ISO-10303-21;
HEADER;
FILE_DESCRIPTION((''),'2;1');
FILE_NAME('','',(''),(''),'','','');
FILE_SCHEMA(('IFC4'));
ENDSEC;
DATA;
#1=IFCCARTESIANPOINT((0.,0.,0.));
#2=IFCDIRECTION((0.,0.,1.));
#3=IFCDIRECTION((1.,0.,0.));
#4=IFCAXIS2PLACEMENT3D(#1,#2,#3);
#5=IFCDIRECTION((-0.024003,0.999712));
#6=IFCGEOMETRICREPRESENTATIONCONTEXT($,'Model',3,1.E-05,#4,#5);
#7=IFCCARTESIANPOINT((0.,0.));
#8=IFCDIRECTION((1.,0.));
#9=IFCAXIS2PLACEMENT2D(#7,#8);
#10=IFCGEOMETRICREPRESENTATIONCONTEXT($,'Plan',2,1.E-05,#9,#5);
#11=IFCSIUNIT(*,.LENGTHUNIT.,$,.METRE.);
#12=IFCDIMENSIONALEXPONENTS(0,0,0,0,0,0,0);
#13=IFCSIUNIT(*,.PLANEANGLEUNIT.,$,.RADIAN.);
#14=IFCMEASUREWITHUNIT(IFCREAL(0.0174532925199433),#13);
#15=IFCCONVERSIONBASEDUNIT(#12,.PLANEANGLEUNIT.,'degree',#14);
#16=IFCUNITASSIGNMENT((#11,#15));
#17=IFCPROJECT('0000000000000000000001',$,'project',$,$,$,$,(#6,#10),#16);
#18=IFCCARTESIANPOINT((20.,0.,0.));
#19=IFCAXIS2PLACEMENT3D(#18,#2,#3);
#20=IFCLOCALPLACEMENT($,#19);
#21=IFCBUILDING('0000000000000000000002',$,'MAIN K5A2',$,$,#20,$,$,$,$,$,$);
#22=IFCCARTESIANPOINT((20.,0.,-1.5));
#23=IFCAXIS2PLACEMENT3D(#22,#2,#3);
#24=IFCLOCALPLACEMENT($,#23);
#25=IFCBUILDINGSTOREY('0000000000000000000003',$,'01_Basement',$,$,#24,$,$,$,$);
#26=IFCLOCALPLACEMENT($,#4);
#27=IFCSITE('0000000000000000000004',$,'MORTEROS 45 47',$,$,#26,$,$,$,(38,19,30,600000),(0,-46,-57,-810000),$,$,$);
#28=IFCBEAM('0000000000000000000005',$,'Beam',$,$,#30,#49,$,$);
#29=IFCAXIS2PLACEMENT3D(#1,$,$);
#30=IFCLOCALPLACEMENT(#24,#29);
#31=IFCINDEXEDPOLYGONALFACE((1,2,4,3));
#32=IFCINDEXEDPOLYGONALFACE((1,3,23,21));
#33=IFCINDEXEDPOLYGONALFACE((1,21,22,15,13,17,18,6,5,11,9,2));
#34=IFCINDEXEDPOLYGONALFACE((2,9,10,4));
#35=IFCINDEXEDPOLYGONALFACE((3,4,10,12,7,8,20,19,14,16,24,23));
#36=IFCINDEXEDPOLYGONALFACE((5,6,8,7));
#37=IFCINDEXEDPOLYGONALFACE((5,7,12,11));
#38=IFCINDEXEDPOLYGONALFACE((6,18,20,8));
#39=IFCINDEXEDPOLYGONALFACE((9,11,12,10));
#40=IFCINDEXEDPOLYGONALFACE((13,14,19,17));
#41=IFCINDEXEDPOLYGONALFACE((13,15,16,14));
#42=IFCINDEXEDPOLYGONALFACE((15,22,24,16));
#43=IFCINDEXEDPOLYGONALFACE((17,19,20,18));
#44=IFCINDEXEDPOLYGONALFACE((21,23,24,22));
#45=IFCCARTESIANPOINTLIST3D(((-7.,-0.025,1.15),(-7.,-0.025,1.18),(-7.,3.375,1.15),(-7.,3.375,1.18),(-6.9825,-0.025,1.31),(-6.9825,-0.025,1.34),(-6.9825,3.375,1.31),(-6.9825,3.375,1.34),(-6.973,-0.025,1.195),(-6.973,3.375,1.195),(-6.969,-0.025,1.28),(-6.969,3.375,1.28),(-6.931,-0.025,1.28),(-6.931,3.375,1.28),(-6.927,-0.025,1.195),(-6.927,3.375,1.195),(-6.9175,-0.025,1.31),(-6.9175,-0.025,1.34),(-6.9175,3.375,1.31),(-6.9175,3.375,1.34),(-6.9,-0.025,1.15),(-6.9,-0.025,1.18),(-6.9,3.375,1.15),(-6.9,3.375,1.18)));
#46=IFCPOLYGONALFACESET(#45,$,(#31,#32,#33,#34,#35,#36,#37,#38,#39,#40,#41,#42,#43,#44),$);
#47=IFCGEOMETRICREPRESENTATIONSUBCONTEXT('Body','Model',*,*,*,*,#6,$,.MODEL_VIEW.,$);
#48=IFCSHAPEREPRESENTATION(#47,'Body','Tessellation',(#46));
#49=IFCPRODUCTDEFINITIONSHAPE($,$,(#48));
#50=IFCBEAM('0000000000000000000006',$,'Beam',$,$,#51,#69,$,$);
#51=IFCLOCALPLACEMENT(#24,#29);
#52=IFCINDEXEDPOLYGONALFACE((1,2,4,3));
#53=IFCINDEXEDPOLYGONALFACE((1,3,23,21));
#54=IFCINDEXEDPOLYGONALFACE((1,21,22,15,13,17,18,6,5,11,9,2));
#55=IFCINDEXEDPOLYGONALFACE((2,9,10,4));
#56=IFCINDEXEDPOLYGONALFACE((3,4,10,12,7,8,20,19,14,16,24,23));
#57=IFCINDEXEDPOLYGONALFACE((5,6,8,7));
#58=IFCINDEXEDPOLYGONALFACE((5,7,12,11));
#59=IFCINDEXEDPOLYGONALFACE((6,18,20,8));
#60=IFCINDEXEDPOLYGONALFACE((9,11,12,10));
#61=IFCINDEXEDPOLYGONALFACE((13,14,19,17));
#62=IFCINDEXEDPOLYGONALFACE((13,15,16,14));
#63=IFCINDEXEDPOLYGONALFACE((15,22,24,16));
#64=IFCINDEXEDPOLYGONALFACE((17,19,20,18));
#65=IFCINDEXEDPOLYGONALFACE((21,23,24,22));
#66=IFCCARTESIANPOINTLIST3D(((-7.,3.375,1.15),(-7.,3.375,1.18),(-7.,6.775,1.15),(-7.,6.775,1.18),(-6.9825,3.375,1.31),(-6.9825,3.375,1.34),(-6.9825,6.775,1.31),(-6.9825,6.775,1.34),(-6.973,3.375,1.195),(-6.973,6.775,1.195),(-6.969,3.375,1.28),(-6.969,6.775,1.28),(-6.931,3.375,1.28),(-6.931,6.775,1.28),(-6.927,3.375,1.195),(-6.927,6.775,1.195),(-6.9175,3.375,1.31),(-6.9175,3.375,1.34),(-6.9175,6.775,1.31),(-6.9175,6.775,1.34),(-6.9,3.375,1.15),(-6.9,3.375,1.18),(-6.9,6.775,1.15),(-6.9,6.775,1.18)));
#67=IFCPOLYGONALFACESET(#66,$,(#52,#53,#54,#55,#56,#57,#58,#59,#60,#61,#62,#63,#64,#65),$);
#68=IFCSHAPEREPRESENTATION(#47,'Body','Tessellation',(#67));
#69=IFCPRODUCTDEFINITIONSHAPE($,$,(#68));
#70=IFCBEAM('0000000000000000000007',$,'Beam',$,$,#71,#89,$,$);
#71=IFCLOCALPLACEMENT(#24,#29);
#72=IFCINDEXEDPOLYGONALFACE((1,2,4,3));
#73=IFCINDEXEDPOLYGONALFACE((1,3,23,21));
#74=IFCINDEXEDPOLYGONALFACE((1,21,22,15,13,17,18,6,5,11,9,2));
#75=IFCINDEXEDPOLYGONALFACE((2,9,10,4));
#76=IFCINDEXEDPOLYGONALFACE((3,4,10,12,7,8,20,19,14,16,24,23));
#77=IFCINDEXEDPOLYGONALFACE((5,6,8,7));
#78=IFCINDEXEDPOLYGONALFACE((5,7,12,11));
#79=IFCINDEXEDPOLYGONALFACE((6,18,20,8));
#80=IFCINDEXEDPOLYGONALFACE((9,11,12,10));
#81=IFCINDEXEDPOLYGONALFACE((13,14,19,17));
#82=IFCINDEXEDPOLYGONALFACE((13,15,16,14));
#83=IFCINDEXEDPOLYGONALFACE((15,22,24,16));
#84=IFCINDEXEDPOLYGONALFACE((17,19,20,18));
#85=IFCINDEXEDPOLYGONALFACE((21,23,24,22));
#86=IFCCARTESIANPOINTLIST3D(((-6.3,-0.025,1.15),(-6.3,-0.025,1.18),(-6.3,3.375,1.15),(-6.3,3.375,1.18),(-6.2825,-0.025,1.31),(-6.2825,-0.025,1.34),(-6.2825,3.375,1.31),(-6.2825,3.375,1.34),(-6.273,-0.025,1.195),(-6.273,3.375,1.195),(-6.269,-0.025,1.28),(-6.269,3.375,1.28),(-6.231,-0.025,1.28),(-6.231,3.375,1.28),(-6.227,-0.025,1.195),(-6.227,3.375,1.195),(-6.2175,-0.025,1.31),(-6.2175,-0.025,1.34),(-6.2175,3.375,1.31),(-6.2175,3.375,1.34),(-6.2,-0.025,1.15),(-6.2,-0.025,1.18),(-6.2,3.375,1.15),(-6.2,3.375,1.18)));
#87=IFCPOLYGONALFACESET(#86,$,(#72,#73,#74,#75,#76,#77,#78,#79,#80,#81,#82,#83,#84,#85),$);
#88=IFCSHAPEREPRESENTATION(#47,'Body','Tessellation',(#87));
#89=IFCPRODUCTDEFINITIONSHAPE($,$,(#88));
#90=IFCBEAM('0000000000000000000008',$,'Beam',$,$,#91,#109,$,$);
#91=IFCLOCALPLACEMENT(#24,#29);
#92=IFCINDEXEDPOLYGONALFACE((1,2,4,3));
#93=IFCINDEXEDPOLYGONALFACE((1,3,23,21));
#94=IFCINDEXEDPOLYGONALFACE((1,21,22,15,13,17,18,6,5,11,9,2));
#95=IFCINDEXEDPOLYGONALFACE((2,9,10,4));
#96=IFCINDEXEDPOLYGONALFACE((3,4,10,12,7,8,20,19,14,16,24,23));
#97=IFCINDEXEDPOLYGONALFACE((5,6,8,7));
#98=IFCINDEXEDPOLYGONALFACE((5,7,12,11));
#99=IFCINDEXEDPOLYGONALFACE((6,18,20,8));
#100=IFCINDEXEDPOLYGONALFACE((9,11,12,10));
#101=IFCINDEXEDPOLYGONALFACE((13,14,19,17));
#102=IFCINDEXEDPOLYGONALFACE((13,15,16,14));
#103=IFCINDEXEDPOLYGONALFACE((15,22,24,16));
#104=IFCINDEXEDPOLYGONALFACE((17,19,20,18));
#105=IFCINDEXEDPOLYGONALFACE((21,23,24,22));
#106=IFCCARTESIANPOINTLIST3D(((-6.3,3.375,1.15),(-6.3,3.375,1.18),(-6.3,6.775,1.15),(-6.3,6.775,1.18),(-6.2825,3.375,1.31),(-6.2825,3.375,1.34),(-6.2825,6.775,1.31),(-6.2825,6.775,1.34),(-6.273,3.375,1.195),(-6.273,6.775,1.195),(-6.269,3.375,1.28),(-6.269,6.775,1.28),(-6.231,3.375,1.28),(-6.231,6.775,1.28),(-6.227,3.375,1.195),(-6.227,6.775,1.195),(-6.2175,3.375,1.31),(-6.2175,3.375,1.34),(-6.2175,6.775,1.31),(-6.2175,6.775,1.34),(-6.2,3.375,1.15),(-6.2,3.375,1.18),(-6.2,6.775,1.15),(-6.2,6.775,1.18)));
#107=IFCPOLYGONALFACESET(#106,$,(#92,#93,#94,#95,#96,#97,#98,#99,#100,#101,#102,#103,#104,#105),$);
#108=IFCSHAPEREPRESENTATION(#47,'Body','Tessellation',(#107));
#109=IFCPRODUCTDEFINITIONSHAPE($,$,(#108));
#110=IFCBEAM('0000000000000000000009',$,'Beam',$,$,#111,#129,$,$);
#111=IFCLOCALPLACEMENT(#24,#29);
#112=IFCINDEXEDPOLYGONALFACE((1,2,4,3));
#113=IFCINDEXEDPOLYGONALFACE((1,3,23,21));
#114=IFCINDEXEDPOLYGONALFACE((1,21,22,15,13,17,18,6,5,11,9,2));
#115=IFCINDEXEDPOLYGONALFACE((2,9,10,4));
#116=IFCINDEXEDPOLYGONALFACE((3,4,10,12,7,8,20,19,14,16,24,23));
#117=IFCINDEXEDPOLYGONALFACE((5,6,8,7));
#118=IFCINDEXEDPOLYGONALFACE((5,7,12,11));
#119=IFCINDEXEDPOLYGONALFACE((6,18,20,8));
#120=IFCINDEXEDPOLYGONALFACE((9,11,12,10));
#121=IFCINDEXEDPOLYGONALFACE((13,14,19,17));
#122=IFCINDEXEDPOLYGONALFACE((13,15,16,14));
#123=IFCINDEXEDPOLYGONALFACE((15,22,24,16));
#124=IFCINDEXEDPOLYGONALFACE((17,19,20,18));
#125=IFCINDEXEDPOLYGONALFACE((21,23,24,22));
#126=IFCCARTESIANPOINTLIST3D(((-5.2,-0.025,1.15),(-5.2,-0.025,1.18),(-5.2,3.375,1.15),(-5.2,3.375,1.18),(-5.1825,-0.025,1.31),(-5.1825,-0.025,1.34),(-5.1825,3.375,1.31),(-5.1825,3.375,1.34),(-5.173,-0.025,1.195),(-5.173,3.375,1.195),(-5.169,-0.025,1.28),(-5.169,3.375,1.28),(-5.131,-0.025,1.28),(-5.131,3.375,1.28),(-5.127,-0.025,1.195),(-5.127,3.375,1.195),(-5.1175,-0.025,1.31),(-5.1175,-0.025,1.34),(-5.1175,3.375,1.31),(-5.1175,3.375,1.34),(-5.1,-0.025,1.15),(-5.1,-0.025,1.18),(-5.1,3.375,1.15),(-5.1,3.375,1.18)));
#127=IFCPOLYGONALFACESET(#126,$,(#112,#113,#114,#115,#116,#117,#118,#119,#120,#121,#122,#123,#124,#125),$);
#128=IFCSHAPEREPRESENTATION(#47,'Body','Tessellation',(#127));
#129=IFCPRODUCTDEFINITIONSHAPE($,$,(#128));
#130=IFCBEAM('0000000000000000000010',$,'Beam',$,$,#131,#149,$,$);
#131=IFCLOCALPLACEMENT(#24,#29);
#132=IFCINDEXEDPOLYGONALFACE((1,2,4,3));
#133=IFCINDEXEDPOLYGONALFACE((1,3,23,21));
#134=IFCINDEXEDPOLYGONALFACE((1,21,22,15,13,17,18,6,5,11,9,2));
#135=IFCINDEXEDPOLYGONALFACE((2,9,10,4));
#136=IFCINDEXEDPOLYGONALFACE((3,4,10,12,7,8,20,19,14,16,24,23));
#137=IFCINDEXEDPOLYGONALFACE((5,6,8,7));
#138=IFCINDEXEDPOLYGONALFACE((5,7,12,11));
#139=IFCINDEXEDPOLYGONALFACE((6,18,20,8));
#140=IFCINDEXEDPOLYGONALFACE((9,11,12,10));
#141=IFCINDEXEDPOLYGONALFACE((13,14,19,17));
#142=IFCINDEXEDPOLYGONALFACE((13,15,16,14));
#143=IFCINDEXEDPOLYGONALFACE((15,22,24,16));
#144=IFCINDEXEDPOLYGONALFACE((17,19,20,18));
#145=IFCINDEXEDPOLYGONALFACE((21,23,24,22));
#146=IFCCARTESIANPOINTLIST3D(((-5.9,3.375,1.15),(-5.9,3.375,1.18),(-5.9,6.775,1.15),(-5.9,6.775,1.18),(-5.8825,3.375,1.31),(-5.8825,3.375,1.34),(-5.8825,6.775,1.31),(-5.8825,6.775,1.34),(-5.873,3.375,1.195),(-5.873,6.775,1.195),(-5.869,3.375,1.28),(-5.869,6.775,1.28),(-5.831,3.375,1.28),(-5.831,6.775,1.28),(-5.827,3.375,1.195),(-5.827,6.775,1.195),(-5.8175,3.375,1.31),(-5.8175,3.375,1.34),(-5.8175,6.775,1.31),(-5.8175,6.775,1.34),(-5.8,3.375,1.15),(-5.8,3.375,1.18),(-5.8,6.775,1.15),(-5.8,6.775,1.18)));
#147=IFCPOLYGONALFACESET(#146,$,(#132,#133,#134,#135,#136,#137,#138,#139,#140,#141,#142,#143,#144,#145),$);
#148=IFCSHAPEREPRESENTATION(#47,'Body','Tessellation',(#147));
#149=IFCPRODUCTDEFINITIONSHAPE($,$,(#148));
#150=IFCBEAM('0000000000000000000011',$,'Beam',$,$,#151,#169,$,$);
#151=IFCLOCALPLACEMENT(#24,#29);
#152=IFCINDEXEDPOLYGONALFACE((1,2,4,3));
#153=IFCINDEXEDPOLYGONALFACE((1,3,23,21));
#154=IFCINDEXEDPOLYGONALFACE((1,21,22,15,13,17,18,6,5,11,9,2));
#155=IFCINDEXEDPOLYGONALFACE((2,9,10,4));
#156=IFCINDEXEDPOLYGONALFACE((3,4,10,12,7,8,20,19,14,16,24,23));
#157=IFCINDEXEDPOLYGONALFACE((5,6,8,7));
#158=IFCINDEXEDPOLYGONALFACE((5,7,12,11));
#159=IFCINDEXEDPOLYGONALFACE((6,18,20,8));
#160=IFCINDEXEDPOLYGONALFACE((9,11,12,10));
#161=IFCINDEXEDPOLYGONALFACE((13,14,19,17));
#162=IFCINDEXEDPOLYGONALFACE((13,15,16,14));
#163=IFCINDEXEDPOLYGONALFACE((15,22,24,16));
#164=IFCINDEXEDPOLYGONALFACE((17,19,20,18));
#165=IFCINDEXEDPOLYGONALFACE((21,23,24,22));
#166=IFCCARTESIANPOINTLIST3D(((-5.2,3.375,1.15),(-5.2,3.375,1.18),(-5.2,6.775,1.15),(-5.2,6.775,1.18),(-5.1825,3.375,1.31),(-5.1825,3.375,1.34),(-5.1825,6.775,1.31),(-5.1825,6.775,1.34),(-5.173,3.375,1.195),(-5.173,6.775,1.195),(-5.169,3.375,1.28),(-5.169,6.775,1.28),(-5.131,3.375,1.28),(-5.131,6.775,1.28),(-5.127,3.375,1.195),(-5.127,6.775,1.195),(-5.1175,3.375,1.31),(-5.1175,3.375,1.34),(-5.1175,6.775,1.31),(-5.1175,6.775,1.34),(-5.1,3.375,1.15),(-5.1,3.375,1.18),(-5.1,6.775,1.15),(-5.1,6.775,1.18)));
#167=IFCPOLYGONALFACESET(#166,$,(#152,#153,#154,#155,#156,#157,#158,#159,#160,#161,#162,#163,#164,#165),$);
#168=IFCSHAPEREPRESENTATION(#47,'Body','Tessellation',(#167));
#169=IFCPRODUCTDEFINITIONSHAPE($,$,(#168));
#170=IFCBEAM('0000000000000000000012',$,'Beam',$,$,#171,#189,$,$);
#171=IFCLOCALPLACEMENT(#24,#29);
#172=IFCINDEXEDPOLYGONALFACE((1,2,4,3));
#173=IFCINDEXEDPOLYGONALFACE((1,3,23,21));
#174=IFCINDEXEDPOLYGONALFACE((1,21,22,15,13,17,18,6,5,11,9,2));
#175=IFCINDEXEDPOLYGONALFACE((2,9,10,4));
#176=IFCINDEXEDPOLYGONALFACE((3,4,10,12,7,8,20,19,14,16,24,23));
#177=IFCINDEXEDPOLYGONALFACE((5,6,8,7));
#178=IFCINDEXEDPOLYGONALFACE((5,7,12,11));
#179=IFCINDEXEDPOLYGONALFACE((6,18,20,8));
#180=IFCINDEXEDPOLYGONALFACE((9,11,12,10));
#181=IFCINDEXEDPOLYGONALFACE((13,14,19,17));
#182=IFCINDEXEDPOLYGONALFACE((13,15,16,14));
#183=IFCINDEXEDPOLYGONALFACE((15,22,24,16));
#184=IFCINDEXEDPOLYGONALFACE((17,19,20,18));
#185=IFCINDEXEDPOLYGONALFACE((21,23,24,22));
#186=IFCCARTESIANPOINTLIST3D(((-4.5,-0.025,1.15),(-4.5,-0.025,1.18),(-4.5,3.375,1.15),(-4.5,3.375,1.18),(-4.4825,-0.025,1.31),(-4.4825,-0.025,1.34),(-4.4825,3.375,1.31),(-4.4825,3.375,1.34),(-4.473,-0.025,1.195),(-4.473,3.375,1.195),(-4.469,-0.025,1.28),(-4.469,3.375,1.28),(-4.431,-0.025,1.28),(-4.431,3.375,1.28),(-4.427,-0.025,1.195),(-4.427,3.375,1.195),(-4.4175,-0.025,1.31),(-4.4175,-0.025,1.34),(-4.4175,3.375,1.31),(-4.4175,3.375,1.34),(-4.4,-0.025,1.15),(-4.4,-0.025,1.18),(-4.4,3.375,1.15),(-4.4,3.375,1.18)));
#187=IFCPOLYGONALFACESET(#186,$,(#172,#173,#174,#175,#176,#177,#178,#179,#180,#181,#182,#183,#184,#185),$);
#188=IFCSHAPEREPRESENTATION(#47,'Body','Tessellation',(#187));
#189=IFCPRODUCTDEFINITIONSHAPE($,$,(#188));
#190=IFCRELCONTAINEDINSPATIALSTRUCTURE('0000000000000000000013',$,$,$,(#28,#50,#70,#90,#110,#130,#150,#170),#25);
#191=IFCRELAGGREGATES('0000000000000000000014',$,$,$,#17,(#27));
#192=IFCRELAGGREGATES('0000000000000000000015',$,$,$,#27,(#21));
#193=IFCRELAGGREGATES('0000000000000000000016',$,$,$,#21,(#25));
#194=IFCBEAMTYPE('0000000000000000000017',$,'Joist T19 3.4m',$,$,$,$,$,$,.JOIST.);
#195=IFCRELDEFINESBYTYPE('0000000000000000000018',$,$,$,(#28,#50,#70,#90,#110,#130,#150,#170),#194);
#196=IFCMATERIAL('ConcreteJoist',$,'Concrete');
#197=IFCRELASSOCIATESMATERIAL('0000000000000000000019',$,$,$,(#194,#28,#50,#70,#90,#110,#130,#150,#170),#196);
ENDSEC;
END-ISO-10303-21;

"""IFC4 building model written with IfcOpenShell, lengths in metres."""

from ifc_helpers import new_model, entity, si_unit, converted_unit, direction, frame, origin_with_axes, origin_2d_with_axis, place, context, subcontext, project, spatial, indexed_curve, outline, extrude, material, material_profile, profile_set, profile_usage, type_object, element, save


model = new_model("IFC4")

# Units and contexts
model_context = context("Model", 3, precision=1e-05, world=origin_with_axes(), true_north=direction((-0.024003, 0.999712)))
plan_context = context("Plan", 2, precision=1e-05, world=origin_2d_with_axis(), true_north=direction((-0.024003, 0.999712)))
body_context = subcontext(model_context, "Body", "Model", "MODEL_VIEW")
ifc_project = project(units=[si_unit("LENGTHUNIT", "METRE"), converted_unit("PLANEANGLEUNIT", "degree", entity("IfcReal", 0.0174532925199433), si_unit("PLANEANGLEUNIT", "RADIAN"), dimensions=[0, 0, 0, 0, 0, 0, 0])], contexts=[model_context, plan_context])

# Site, building, storey
site_placement = place(None, origin_with_axes())
site = spatial("IfcSite", under=ifc_project, at=site_placement, Name="MORTEROS 45 47", RefLatitude=(38, 19, 30, 600000), RefLongitude=(0, -46, -57, -810000))
building_placement = place(None, frame((20.0, 0.0, 0.0), z_axis=(0.0, 0.0, 1.0), x_axis=(1.0, 0.0, 0.0)))
building = spatial("IfcBuilding", under=site, at=building_placement, Name="MAIN K5A2")
storey_placement = place(None, frame((20.0, 0.0, -1.5), z_axis=(0.0, 0.0, 1.0), x_axis=(1.0, 0.0, 0.0)))
storey = spatial("IfcBuildingStorey", under=building, at=storey_placement, Name="01_Basement")

# Beams
ifc_material = material(Name="ConcreteJoist", Category="Concrete")
ifc_material_profile = material_profile(ifc_material, outline(indexed_curve([(0.019, 0.13), (0.023, 0.045), (0.05, 0.03), (0.05, 0.0), (-0.05, 0.0), (-0.05, 0.03), (-0.023, 0.045), (-0.019, 0.13), (-0.0325, 0.16), (-0.0325, 0.19), (0.0325, 0.19), (0.0325, 0.16), (0.019, 0.13)])))
ifc_profile_set = profile_set([ifc_material_profile], Name="JoistMaterialProfileSet")
ifc_profile_usage_1 = profile_usage(ifc_profile_set, cardinal=5)
beam_type = type_object("IfcBeamType", Name="Joist T19 3.4m", PredefinedType="JOIST", material=ifc_profile_set)
beam_1_placement = place(None, frame((13.05, -0.025, -0.35), z_axis=(0.0, 1.0, 0.0), x_axis=(-1.0, 0.0, 0.0)))
element("IfcBeam", 1, at=beam_1_placement, inside=storey, type_object=beam_type, material=ifc_profile_usage_1, Name="Beam", context=body_context, shape_type="SweptSolid", body=[
    extrude(outline(indexed_curve([(0.019, 0.13), (0.023, 0.045), (0.05, 0.03), (0.05, 0.0), (-0.05, 0.0), (-0.05, 0.03), (-0.023, 0.045), (-0.019, 0.13), (-0.0325, 0.16), (-0.0325, 0.19), (0.0325, 0.19), (0.0325, 0.16), (0.019, 0.13)])), origin_with_axes(), (0.0, 0.0, 1.0), 3.4),
])
ifc_profile_usage_2 = profile_usage(ifc_profile_set, cardinal=5)
beam_2_placement = place(None, frame((13.05, 3.375, -0.35), z_axis=(0.0, 1.0, 0.0), x_axis=(-1.0, 0.0, 0.0)))
element("IfcBeam", 2, at=beam_2_placement, inside=storey, type_object=beam_type, material=ifc_profile_usage_2, Name="Beam", context=body_context, shape_type="SweptSolid", body=[
    extrude(outline(indexed_curve([(0.019, 0.13), (0.023, 0.045), (0.05, 0.03), (0.05, 0.0), (-0.05, 0.0), (-0.05, 0.03), (-0.023, 0.045), (-0.019, 0.13), (-0.0325, 0.16), (-0.0325, 0.19), (0.0325, 0.19), (0.0325, 0.16), (0.019, 0.13)])), origin_with_axes(), (0.0, 0.0, 1.0), 3.4),
])
ifc_profile_usage_3 = profile_usage(ifc_profile_set, cardinal=5)
beam_3_placement = place(None, frame((13.75, -0.025, -0.35), z_axis=(0.0, 1.0, 0.0), x_axis=(-1.0, 0.0, 0.0)))
element("IfcBeam", 3, at=beam_3_placement, inside=storey, type_object=beam_type, material=ifc_profile_usage_3, Name="Beam", context=body_context, shape_type="SweptSolid", body=[
    extrude(outline(indexed_curve([(0.019, 0.13), (0.023, 0.045), (0.05, 0.03), (0.05, 0.0), (-0.05, 0.0), (-0.05, 0.03), (-0.023, 0.045), (-0.019, 0.13), (-0.0325, 0.16), (-0.0325, 0.19), (0.0325, 0.19), (0.0325, 0.16), (0.019, 0.13)])), origin_with_axes(), (0.0, 0.0, 1.0), 3.4),
])
ifc_profile_usage_4 = profile_usage(ifc_profile_set, cardinal=5)
beam_4_placement = place(None, frame((13.75, 3.375, -0.35), z_axis=(0.0, 1.0, 0.0), x_axis=(-1.0, 0.0, 0.0)))
element("IfcBeam", 4, at=beam_4_placement, inside=storey, type_object=beam_type, material=ifc_profile_usage_4, Name="Beam", context=body_context, shape_type="SweptSolid", body=[
    extrude(outline(indexed_curve([(0.019, 0.13), (0.023, 0.045), (0.05, 0.03), (0.05, 0.0), (-0.05, 0.0), (-0.05, 0.03), (-0.023, 0.045), (-0.019, 0.13), (-0.0325, 0.16), (-0.0325, 0.19), (0.0325, 0.19), (0.0325, 0.16), (0.019, 0.13)])), origin_with_axes(), (0.0, 0.0, 1.0), 3.4),
])
ifc_profile_usage_5 = profile_usage(ifc_profile_set, cardinal=5)
beam_5_placement = place(None, frame((14.85, -0.025, -0.35), z_axis=(0.0, 1.0, 0.0), x_axis=(-1.0, 0.0, 0.0)))
element("IfcBeam", 5, at=beam_5_placement, inside=storey, type_object=beam_type, material=ifc_profile_usage_5, Name="Beam", context=body_context, shape_type="SweptSolid", body=[
    extrude(outline(indexed_curve([(0.019, 0.13), (0.023, 0.045), (0.05, 0.03), (0.05, 0.0), (-0.05, 0.0), (-0.05, 0.03), (-0.023, 0.045), (-0.019, 0.13), (-0.0325, 0.16), (-0.0325, 0.19), (0.0325, 0.19), (0.0325, 0.16), (0.019, 0.13)])), origin_with_axes(), (0.0, 0.0, 1.0), 3.4),
])
ifc_profile_usage_6 = profile_usage(ifc_profile_set, cardinal=5)
beam_6_placement = place(None, frame((14.15, 3.375, -0.35), z_axis=(0.0, 1.0, 0.0), x_axis=(-1.0, 0.0, 0.0)))
element("IfcBeam", 6, at=beam_6_placement, inside=storey, type_object=beam_type, material=ifc_profile_usage_6, Name="Beam", context=body_context, shape_type="SweptSolid", body=[
    extrude(outline(indexed_curve([(0.019, 0.13), (0.023, 0.045), (0.05, 0.03), (0.05, 0.0), (-0.05, 0.0), (-0.05, 0.03), (-0.023, 0.045), (-0.019, 0.13), (-0.0325, 0.16), (-0.0325, 0.19), (0.0325, 0.19), (0.0325, 0.16), (0.019, 0.13)])), origin_with_axes(), (0.0, 0.0, 1.0), 3.4),
])
ifc_profile_usage_7 = profile_usage(ifc_profile_set, cardinal=5)
beam_7_placement = place(None, frame((14.85, 3.375, -0.35), z_axis=(0.0, 1.0, 0.0), x_axis=(-1.0, 0.0, 0.0)))
element("IfcBeam", 7, at=beam_7_placement, inside=storey, type_object=beam_type, material=ifc_profile_usage_7, Name="Beam", context=body_context, shape_type="SweptSolid", body=[
    extrude(outline(indexed_curve([(0.019, 0.13), (0.023, 0.045), (0.05, 0.03), (0.05, 0.0), (-0.05, 0.0), (-0.05, 0.03), (-0.023, 0.045), (-0.019, 0.13), (-0.0325, 0.16), (-0.0325, 0.19), (0.0325, 0.19), (0.0325, 0.16), (0.019, 0.13)])), origin_with_axes(), (0.0, 0.0, 1.0), 3.4),
])
ifc_profile_usage_8 = profile_usage(ifc_profile_set, cardinal=5)
beam_8_placement = place(None, frame((15.55, -0.025, -0.35), z_axis=(0.0, 1.0, 0.0), x_axis=(-1.0, 0.0, 0.0)))
element("IfcBeam", 8, at=beam_8_placement, inside=storey, type_object=beam_type, material=ifc_profile_usage_8, Name="Beam", context=body_context, shape_type="SweptSolid", body=[
    extrude(outline(indexed_curve([(0.019, 0.13), (0.023, 0.045), (0.05, 0.03), (0.05, 0.0), (-0.05, 0.0), (-0.05, 0.03), (-0.023, 0.045), (-0.019, 0.13), (-0.0325, 0.16), (-0.0325, 0.19), (0.0325, 0.19), (0.0325, 0.16), (0.019, 0.13)])), origin_with_axes(), (0.0, 0.0, 1.0), 3.4),
])

save(model, "model.ifc")
